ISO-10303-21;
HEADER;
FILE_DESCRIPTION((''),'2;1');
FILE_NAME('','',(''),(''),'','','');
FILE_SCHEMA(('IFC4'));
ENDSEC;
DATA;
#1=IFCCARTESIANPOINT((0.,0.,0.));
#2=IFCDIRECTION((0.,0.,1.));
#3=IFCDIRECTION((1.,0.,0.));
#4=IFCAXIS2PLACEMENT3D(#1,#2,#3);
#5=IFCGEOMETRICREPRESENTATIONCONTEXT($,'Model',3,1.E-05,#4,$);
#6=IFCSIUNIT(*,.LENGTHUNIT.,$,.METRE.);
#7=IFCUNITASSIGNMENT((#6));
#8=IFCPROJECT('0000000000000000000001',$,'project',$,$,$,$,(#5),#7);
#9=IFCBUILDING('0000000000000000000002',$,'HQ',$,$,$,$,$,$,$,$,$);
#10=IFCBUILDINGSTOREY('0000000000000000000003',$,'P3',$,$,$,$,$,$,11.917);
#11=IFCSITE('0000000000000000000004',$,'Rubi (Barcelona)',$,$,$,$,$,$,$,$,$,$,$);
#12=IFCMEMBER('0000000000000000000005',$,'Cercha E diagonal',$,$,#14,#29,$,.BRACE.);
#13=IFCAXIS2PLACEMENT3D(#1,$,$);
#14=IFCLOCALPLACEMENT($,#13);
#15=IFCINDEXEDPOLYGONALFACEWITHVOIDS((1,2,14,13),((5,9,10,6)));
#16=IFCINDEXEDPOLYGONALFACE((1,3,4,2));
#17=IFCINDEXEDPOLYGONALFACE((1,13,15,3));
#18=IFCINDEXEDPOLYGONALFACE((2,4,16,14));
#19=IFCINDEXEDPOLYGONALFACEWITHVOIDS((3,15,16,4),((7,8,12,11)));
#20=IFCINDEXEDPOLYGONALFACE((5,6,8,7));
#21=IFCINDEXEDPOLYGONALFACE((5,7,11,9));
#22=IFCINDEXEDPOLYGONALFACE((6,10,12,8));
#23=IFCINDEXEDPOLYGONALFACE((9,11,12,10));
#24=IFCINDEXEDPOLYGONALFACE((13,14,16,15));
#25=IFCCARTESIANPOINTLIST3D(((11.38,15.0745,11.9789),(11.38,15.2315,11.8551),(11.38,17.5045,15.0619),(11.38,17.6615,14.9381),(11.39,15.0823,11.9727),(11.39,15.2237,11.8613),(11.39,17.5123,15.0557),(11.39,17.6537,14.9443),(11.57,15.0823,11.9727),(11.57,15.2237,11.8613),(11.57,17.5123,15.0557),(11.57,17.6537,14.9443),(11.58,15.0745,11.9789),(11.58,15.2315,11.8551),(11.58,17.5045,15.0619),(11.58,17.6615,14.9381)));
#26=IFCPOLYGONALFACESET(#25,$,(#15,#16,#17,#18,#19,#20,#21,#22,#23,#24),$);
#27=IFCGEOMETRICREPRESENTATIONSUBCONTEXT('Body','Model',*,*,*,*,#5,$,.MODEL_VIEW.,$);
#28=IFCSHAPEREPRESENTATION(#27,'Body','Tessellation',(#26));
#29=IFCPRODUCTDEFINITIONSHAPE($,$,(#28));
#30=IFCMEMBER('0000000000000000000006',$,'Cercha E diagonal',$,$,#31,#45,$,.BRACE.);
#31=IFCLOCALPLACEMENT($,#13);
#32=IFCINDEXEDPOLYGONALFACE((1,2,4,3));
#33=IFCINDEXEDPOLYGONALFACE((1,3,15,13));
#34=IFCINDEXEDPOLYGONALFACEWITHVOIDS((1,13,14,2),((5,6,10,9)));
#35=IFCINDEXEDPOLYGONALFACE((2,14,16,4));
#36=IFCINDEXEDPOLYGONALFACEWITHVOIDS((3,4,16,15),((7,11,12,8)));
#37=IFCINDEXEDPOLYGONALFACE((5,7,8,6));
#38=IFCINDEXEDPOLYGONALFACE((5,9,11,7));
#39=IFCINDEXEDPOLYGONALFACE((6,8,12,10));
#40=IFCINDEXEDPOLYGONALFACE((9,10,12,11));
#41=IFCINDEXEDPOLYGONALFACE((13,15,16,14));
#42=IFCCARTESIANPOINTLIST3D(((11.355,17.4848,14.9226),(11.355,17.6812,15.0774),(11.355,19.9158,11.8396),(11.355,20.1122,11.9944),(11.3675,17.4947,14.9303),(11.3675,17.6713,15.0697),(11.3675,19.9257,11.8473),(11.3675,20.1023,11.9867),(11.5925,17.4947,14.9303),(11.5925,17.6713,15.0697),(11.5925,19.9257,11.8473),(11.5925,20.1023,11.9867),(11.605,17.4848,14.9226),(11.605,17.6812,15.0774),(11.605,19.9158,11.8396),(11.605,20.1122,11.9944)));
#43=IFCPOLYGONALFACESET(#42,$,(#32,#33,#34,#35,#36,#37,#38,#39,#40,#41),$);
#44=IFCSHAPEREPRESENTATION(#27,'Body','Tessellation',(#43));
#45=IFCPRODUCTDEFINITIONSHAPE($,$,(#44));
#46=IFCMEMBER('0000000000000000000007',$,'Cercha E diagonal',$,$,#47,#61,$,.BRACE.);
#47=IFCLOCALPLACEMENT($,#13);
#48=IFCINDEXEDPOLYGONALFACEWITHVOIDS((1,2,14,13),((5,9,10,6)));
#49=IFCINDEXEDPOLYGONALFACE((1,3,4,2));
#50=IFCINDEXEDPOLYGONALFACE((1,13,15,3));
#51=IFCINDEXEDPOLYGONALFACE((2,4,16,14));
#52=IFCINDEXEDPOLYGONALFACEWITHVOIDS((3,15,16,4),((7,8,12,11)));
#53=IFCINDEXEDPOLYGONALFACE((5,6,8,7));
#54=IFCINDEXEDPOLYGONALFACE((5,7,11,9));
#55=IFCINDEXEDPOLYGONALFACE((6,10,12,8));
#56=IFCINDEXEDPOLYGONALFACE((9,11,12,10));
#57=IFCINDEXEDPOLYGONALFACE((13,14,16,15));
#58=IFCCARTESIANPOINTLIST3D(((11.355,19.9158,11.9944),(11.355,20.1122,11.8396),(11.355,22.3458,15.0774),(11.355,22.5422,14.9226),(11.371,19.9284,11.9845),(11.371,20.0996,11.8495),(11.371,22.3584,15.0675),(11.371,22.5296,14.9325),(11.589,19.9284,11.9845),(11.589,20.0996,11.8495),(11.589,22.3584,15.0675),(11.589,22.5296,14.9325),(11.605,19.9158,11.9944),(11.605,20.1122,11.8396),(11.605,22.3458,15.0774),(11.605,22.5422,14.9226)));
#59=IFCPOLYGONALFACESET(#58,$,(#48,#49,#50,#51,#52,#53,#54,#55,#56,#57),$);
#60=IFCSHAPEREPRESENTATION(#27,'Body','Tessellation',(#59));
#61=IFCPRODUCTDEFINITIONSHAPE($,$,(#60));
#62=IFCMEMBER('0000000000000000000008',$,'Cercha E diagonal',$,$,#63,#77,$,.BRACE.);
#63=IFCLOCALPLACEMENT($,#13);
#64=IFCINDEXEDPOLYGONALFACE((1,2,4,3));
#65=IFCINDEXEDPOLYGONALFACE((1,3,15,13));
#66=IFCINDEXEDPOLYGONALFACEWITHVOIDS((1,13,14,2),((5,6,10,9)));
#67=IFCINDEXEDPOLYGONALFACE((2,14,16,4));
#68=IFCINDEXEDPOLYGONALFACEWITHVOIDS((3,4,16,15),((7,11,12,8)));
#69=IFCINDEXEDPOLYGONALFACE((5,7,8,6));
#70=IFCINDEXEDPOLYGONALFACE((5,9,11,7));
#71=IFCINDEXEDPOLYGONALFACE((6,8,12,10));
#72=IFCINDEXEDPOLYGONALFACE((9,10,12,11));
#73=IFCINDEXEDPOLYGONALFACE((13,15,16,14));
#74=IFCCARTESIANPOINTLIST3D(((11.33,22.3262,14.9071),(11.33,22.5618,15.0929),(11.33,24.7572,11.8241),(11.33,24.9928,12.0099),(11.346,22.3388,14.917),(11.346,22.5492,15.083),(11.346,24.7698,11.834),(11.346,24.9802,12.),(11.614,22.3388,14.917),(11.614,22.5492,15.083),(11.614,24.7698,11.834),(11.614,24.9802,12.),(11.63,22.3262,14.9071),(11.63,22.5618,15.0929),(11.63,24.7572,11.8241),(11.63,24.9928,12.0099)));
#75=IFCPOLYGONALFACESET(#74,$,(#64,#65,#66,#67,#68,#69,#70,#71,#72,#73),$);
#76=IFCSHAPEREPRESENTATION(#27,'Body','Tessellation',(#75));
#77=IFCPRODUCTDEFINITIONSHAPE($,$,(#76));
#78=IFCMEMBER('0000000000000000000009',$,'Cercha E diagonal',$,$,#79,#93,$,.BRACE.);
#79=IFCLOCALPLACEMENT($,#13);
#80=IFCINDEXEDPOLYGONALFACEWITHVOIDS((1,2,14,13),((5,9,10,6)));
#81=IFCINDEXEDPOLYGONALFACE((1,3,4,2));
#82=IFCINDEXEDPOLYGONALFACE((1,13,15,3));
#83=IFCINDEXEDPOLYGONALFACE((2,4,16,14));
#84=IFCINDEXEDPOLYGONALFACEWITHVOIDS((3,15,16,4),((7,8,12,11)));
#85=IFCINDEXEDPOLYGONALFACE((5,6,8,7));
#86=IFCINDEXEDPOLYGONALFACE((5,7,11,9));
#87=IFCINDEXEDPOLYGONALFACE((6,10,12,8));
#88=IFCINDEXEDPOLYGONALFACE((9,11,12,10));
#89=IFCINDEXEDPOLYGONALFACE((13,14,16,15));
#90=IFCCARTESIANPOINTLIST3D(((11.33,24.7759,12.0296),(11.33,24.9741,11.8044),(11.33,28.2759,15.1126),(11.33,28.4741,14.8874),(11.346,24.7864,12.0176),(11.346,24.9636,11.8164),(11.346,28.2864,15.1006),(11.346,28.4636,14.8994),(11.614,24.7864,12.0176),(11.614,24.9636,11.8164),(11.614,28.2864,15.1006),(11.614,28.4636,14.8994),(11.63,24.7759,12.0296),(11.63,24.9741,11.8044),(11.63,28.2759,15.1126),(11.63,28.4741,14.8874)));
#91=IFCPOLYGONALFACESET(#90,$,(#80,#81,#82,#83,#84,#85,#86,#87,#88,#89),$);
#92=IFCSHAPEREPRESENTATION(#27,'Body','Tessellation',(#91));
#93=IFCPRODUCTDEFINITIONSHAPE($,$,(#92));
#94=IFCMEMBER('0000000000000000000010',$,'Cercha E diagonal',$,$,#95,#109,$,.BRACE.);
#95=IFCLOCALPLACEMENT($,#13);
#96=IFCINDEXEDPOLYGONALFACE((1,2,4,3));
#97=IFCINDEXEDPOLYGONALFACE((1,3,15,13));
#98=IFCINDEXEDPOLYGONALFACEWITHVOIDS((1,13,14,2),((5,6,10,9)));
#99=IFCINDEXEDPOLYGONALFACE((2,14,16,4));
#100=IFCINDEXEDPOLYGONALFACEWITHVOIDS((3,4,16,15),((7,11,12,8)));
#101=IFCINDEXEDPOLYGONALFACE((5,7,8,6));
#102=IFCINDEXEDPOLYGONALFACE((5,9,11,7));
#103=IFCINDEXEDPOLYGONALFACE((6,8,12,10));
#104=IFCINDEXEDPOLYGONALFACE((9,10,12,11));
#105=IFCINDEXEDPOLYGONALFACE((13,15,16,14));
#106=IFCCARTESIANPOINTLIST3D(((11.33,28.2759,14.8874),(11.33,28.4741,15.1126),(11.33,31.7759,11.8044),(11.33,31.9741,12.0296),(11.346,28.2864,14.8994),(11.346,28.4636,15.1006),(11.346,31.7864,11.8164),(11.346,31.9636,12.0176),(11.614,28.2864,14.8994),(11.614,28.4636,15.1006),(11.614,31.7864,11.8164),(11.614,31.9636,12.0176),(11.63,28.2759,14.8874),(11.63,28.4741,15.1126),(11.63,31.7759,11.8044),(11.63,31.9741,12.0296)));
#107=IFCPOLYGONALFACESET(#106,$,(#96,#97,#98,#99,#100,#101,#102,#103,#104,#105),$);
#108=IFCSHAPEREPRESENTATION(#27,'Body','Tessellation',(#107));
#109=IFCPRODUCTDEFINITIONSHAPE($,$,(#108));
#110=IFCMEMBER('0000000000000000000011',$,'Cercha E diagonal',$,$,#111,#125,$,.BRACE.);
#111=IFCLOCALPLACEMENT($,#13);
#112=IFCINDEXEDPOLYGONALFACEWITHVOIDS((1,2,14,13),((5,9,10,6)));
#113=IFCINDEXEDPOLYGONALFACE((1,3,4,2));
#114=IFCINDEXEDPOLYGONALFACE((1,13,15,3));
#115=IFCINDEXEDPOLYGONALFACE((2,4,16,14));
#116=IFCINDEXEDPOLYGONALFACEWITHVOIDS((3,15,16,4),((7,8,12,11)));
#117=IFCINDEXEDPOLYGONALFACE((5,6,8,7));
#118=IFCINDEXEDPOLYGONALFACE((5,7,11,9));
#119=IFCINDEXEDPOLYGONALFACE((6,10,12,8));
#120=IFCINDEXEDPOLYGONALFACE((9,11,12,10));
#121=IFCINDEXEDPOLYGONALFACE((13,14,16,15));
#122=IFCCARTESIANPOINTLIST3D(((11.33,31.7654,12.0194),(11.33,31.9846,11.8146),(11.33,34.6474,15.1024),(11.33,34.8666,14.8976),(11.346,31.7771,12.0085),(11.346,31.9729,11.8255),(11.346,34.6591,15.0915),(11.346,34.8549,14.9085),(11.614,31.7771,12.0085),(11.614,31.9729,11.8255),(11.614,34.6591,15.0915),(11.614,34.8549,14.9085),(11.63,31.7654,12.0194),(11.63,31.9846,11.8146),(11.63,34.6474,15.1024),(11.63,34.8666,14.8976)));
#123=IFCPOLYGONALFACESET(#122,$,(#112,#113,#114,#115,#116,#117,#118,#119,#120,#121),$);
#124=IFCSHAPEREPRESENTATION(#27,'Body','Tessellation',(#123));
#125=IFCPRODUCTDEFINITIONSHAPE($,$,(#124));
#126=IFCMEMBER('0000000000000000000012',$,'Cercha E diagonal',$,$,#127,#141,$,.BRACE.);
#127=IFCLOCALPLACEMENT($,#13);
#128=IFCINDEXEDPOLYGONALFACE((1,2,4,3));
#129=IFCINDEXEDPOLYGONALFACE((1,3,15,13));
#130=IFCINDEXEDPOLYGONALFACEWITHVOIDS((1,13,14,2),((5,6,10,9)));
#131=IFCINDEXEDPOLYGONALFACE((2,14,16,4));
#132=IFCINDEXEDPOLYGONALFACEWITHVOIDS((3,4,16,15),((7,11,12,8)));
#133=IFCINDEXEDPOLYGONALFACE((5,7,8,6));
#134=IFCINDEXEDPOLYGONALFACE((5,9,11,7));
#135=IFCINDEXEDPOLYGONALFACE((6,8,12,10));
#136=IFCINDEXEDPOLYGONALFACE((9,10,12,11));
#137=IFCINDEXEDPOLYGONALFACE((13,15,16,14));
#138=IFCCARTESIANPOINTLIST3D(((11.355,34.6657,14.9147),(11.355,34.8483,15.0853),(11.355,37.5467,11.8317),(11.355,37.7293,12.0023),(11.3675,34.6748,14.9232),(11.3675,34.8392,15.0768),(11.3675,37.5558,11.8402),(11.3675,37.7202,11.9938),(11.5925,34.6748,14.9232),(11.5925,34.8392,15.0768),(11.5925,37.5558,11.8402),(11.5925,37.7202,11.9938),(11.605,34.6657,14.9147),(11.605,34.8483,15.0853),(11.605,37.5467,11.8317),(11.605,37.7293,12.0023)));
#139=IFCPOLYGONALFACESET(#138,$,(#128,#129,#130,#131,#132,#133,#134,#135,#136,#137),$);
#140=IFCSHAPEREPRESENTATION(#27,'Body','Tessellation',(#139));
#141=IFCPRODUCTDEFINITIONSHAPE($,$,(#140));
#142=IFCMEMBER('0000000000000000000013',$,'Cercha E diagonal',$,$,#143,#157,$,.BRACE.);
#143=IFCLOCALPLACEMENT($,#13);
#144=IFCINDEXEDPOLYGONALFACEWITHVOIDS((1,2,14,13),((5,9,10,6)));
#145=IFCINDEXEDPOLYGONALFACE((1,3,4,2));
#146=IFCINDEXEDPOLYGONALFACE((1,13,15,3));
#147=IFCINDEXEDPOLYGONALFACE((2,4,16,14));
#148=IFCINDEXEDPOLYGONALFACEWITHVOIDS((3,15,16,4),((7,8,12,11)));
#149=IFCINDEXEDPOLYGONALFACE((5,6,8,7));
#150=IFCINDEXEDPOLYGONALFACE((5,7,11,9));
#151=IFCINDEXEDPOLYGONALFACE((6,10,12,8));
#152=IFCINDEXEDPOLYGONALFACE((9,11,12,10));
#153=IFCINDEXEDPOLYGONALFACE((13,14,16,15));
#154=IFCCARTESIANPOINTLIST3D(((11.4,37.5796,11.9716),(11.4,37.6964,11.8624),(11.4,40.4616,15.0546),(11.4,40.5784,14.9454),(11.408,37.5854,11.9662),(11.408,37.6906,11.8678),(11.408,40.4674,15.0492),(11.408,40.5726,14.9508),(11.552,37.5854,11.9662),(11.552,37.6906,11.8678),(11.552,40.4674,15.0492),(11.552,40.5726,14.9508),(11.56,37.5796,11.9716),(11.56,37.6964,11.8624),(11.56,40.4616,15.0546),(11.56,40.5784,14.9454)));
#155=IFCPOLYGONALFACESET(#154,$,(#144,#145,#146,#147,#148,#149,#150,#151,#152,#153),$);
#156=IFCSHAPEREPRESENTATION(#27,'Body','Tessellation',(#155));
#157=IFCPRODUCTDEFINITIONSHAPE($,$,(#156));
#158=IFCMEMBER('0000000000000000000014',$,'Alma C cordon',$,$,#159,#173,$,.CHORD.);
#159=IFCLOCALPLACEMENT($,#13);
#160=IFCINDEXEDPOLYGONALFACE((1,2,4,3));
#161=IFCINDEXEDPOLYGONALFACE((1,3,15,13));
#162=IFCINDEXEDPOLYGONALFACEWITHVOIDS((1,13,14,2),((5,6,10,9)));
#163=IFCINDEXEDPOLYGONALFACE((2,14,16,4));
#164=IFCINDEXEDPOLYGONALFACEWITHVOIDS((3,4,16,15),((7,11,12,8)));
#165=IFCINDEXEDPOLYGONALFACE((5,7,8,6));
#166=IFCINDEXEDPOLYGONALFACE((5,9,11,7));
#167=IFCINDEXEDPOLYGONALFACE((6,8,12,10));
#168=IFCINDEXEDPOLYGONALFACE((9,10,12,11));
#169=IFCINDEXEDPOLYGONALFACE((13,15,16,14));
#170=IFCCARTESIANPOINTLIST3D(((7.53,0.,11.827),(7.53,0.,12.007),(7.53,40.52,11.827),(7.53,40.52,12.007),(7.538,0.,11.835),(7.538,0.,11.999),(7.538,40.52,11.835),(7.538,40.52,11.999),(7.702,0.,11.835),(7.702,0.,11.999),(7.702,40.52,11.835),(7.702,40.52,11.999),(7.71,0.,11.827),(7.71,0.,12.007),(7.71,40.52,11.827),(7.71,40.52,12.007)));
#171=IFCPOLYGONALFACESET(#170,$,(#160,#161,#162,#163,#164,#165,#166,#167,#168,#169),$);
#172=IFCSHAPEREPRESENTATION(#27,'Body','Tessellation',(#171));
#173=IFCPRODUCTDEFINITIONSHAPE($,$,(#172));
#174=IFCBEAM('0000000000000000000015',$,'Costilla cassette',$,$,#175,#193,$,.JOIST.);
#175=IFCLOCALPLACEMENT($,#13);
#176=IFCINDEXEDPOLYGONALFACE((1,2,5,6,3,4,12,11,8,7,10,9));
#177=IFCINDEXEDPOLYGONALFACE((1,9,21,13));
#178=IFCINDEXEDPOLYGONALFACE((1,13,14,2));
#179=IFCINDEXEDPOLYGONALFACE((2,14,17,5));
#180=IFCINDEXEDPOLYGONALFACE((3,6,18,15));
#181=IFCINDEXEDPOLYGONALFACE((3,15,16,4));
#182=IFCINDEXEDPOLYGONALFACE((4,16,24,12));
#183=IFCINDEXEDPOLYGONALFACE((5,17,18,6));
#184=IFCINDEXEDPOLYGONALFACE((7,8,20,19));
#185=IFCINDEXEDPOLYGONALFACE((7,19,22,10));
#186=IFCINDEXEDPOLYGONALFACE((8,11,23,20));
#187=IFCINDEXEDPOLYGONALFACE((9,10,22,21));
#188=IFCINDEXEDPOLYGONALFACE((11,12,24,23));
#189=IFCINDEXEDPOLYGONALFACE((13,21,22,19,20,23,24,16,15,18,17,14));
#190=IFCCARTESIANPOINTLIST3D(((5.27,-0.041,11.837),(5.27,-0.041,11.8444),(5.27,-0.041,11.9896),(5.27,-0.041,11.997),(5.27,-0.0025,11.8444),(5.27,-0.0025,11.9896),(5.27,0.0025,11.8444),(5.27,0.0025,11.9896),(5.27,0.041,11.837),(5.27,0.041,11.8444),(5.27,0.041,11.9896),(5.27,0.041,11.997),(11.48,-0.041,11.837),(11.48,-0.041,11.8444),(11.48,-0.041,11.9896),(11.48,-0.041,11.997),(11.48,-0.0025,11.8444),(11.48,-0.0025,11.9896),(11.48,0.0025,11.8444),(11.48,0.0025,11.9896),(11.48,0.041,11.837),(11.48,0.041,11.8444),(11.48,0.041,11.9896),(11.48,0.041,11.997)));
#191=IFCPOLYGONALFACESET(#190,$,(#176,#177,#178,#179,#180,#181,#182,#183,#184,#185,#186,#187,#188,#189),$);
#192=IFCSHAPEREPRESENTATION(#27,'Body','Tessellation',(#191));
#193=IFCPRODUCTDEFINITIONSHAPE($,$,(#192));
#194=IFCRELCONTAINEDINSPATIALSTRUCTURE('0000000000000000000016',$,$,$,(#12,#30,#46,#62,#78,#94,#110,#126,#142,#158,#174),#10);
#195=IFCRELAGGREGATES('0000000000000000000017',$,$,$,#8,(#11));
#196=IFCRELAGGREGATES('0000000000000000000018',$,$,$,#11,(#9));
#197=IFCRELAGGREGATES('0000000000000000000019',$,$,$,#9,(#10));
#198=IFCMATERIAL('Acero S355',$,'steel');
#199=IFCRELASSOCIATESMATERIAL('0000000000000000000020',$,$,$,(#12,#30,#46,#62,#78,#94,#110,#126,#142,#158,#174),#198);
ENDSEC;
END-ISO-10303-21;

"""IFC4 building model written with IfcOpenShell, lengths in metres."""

from ifc_helpers import new_model, si_unit, frame, origin_with_axes, place, context, subcontext, project, spatial, hollow_rectangle, i_section, extrude, material, element, save


model = new_model("IFC4")

# Units and contexts
model_context = context("Model", 3, precision=1e-05, world=origin_with_axes())
body_context = subcontext(model_context, "Body", "Model", "MODEL_VIEW")
ifc_project = project(units=[si_unit("LENGTHUNIT", "METRE")], contexts=[model_context])

# Site, building, storey
site = spatial("IfcSite", under=ifc_project, Name="Rubi (Barcelona)")
building = spatial("IfcBuilding", under=site, Name="HQ")
storey = spatial("IfcBuildingStorey", under=building, Name="P3", Elevation=11.917)

# Members
ifc_material = material(Name="Acero S355", Category="steel")
member_1_placement = place(None, origin_with_axes())
element("IfcMember", 1, at=member_1_placement, inside=storey, material=ifc_material, Name="Cercha E diagonal", PredefinedType="BRACE", context=body_context, shape_type="SweptSolid", body=[
    extrude(hollow_rectangle(XDim=0.2, YDim=0.2, WallThickness=0.01), frame((11.48, 15.153, 11.917), z_axis=(0.0, 0.619025, 0.785372), x_axis=(-1.0, 0.0, 0.0)), (0.0, 0.0, 1.0), 3.9255),
])
member_2_placement = place(None, origin_with_axes())
element("IfcMember", 2, at=member_2_placement, inside=storey, material=ifc_material, Name="Cercha E diagonal", PredefinedType="BRACE", context=body_context, shape_type="SweptSolid", body=[
    extrude(hollow_rectangle(XDim=0.25, YDim=0.25, WallThickness=0.0125), frame((11.48, 20.014, 11.917), z_axis=(0.0, -0.619182, 0.785248), x_axis=(1.0, 0.0, 0.0)), (0.0, 0.0, 1.0), 3.9261),
])
member_3_placement = place(None, origin_with_axes())
element("IfcMember", 3, at=member_3_placement, inside=storey, material=ifc_material, Name="Cercha E diagonal", PredefinedType="BRACE", context=body_context, shape_type="SweptSolid", body=[
    extrude(hollow_rectangle(XDim=0.25, YDim=0.25, WallThickness=0.016), frame((11.48, 20.014, 11.917), z_axis=(0.0, 0.619025, 0.785372), x_axis=(-1.0, 0.0, 0.0)), (0.0, 0.0, 1.0), 3.9255),
])
member_4_placement = place(None, origin_with_axes())
element("IfcMember", 4, at=member_4_placement, inside=storey, material=ifc_material, Name="Cercha E diagonal", PredefinedType="BRACE", context=body_context, shape_type="SweptSolid", body=[
    extrude(hollow_rectangle(XDim=0.3, YDim=0.3, WallThickness=0.016), frame((11.48, 24.875, 11.917), z_axis=(0.0, -0.619182, 0.785248), x_axis=(1.0, 0.0, 0.0)), (0.0, 0.0, 1.0), 3.9261),
])
member_5_placement = place(None, origin_with_axes())
element("IfcMember", 5, at=member_5_placement, inside=storey, material=ifc_material, Name="Cercha E diagonal", PredefinedType="BRACE", context=body_context, shape_type="SweptSolid", body=[
    extrude(hollow_rectangle(XDim=0.3, YDim=0.3, WallThickness=0.016), frame((11.48, 24.875, 11.917), z_axis=(0.0, 0.750394, 0.66099), x_axis=(-1.0, 0.0, 0.0)), (0.0, 0.0, 1.0), 4.6642),
])
member_6_placement = place(None, origin_with_axes())
element("IfcMember", 6, at=member_6_placement, inside=storey, material=ifc_material, Name="Cercha E diagonal", PredefinedType="BRACE", context=body_context, shape_type="SweptSolid", body=[
    extrude(hollow_rectangle(XDim=0.3, YDim=0.3, WallThickness=0.016), frame((11.48, 31.875, 11.917), z_axis=(0.0, -0.750394, 0.66099), x_axis=(1.0, 0.0, 0.0)), (0.0, 0.0, 1.0), 4.6642),
])
member_7_placement = place(None, origin_with_axes())
element("IfcMember", 7, at=member_7_placement, inside=storey, material=ifc_material, Name="Cercha E diagonal", PredefinedType="BRACE", context=body_context, shape_type="SweptSolid", body=[
    extrude(hollow_rectangle(XDim=0.3, YDim=0.3, WallThickness=0.016), frame((11.48, 31.875, 11.917), z_axis=(0.0, 0.682892, 0.730519), x_axis=(-1.0, 0.0, 0.0)), (0.0, 0.0, 1.0), 4.2203),
])
member_8_placement = place(None, origin_with_axes())
element("IfcMember", 8, at=member_8_placement, inside=storey, material=ifc_material, Name="Cercha E diagonal", PredefinedType="BRACE", context=body_context, shape_type="SweptSolid", body=[
    extrude(hollow_rectangle(XDim=0.25, YDim=0.25, WallThickness=0.0125), frame((11.48, 37.638, 11.917), z_axis=(0.0, -0.682766, 0.730637), x_axis=(1.0, 0.0, 0.0)), (0.0, 0.0, 1.0), 4.2196),
])
member_9_placement = place(None, origin_with_axes())
element("IfcMember", 9, at=member_9_placement, inside=storey, material=ifc_material, Name="Cercha E diagonal", PredefinedType="BRACE", context=body_context, shape_type="SweptSolid", body=[
    extrude(hollow_rectangle(XDim=0.16, YDim=0.16, WallThickness=0.008), frame((11.48, 37.638, 11.917), z_axis=(0.0, 0.682892, 0.730519), x_axis=(-1.0, 0.0, 0.0)), (0.0, 0.0, 1.0), 4.2203),
])
member_10_placement = place(None, origin_with_axes())
element("IfcMember", 10, at=member_10_placement, inside=storey, material=ifc_material, Name="Alma C cordon", PredefinedType="CHORD", context=body_context, shape_type="SweptSolid", body=[
    extrude(hollow_rectangle(XDim=0.18, YDim=0.18, WallThickness=0.008), frame((7.62, 0.0, 11.917), z_axis=(0.0, 1.0, 0.0), x_axis=(-1.0, 0.0, 0.0)), (0.0, 0.0, 1.0), 40.52),
])

# Beam
beam_1_placement = place(None, origin_with_axes())
element("IfcBeam", 11, at=beam_1_placement, inside=storey, material=ifc_material, Name="Costilla cassette", PredefinedType="JOIST", context=body_context, shape_type="SweptSolid", body=[
    extrude(i_section(OverallWidth=0.082, OverallDepth=0.16, WebThickness=0.005, FlangeThickness=0.0074), frame((5.27, 0.0, 11.917), z_axis=(1.0, 0.0, 0.0), x_axis=(0.0, 1.0, 0.0)), (0.0, 0.0, 1.0), 6.21),
])

save(model, "model.ifc")
